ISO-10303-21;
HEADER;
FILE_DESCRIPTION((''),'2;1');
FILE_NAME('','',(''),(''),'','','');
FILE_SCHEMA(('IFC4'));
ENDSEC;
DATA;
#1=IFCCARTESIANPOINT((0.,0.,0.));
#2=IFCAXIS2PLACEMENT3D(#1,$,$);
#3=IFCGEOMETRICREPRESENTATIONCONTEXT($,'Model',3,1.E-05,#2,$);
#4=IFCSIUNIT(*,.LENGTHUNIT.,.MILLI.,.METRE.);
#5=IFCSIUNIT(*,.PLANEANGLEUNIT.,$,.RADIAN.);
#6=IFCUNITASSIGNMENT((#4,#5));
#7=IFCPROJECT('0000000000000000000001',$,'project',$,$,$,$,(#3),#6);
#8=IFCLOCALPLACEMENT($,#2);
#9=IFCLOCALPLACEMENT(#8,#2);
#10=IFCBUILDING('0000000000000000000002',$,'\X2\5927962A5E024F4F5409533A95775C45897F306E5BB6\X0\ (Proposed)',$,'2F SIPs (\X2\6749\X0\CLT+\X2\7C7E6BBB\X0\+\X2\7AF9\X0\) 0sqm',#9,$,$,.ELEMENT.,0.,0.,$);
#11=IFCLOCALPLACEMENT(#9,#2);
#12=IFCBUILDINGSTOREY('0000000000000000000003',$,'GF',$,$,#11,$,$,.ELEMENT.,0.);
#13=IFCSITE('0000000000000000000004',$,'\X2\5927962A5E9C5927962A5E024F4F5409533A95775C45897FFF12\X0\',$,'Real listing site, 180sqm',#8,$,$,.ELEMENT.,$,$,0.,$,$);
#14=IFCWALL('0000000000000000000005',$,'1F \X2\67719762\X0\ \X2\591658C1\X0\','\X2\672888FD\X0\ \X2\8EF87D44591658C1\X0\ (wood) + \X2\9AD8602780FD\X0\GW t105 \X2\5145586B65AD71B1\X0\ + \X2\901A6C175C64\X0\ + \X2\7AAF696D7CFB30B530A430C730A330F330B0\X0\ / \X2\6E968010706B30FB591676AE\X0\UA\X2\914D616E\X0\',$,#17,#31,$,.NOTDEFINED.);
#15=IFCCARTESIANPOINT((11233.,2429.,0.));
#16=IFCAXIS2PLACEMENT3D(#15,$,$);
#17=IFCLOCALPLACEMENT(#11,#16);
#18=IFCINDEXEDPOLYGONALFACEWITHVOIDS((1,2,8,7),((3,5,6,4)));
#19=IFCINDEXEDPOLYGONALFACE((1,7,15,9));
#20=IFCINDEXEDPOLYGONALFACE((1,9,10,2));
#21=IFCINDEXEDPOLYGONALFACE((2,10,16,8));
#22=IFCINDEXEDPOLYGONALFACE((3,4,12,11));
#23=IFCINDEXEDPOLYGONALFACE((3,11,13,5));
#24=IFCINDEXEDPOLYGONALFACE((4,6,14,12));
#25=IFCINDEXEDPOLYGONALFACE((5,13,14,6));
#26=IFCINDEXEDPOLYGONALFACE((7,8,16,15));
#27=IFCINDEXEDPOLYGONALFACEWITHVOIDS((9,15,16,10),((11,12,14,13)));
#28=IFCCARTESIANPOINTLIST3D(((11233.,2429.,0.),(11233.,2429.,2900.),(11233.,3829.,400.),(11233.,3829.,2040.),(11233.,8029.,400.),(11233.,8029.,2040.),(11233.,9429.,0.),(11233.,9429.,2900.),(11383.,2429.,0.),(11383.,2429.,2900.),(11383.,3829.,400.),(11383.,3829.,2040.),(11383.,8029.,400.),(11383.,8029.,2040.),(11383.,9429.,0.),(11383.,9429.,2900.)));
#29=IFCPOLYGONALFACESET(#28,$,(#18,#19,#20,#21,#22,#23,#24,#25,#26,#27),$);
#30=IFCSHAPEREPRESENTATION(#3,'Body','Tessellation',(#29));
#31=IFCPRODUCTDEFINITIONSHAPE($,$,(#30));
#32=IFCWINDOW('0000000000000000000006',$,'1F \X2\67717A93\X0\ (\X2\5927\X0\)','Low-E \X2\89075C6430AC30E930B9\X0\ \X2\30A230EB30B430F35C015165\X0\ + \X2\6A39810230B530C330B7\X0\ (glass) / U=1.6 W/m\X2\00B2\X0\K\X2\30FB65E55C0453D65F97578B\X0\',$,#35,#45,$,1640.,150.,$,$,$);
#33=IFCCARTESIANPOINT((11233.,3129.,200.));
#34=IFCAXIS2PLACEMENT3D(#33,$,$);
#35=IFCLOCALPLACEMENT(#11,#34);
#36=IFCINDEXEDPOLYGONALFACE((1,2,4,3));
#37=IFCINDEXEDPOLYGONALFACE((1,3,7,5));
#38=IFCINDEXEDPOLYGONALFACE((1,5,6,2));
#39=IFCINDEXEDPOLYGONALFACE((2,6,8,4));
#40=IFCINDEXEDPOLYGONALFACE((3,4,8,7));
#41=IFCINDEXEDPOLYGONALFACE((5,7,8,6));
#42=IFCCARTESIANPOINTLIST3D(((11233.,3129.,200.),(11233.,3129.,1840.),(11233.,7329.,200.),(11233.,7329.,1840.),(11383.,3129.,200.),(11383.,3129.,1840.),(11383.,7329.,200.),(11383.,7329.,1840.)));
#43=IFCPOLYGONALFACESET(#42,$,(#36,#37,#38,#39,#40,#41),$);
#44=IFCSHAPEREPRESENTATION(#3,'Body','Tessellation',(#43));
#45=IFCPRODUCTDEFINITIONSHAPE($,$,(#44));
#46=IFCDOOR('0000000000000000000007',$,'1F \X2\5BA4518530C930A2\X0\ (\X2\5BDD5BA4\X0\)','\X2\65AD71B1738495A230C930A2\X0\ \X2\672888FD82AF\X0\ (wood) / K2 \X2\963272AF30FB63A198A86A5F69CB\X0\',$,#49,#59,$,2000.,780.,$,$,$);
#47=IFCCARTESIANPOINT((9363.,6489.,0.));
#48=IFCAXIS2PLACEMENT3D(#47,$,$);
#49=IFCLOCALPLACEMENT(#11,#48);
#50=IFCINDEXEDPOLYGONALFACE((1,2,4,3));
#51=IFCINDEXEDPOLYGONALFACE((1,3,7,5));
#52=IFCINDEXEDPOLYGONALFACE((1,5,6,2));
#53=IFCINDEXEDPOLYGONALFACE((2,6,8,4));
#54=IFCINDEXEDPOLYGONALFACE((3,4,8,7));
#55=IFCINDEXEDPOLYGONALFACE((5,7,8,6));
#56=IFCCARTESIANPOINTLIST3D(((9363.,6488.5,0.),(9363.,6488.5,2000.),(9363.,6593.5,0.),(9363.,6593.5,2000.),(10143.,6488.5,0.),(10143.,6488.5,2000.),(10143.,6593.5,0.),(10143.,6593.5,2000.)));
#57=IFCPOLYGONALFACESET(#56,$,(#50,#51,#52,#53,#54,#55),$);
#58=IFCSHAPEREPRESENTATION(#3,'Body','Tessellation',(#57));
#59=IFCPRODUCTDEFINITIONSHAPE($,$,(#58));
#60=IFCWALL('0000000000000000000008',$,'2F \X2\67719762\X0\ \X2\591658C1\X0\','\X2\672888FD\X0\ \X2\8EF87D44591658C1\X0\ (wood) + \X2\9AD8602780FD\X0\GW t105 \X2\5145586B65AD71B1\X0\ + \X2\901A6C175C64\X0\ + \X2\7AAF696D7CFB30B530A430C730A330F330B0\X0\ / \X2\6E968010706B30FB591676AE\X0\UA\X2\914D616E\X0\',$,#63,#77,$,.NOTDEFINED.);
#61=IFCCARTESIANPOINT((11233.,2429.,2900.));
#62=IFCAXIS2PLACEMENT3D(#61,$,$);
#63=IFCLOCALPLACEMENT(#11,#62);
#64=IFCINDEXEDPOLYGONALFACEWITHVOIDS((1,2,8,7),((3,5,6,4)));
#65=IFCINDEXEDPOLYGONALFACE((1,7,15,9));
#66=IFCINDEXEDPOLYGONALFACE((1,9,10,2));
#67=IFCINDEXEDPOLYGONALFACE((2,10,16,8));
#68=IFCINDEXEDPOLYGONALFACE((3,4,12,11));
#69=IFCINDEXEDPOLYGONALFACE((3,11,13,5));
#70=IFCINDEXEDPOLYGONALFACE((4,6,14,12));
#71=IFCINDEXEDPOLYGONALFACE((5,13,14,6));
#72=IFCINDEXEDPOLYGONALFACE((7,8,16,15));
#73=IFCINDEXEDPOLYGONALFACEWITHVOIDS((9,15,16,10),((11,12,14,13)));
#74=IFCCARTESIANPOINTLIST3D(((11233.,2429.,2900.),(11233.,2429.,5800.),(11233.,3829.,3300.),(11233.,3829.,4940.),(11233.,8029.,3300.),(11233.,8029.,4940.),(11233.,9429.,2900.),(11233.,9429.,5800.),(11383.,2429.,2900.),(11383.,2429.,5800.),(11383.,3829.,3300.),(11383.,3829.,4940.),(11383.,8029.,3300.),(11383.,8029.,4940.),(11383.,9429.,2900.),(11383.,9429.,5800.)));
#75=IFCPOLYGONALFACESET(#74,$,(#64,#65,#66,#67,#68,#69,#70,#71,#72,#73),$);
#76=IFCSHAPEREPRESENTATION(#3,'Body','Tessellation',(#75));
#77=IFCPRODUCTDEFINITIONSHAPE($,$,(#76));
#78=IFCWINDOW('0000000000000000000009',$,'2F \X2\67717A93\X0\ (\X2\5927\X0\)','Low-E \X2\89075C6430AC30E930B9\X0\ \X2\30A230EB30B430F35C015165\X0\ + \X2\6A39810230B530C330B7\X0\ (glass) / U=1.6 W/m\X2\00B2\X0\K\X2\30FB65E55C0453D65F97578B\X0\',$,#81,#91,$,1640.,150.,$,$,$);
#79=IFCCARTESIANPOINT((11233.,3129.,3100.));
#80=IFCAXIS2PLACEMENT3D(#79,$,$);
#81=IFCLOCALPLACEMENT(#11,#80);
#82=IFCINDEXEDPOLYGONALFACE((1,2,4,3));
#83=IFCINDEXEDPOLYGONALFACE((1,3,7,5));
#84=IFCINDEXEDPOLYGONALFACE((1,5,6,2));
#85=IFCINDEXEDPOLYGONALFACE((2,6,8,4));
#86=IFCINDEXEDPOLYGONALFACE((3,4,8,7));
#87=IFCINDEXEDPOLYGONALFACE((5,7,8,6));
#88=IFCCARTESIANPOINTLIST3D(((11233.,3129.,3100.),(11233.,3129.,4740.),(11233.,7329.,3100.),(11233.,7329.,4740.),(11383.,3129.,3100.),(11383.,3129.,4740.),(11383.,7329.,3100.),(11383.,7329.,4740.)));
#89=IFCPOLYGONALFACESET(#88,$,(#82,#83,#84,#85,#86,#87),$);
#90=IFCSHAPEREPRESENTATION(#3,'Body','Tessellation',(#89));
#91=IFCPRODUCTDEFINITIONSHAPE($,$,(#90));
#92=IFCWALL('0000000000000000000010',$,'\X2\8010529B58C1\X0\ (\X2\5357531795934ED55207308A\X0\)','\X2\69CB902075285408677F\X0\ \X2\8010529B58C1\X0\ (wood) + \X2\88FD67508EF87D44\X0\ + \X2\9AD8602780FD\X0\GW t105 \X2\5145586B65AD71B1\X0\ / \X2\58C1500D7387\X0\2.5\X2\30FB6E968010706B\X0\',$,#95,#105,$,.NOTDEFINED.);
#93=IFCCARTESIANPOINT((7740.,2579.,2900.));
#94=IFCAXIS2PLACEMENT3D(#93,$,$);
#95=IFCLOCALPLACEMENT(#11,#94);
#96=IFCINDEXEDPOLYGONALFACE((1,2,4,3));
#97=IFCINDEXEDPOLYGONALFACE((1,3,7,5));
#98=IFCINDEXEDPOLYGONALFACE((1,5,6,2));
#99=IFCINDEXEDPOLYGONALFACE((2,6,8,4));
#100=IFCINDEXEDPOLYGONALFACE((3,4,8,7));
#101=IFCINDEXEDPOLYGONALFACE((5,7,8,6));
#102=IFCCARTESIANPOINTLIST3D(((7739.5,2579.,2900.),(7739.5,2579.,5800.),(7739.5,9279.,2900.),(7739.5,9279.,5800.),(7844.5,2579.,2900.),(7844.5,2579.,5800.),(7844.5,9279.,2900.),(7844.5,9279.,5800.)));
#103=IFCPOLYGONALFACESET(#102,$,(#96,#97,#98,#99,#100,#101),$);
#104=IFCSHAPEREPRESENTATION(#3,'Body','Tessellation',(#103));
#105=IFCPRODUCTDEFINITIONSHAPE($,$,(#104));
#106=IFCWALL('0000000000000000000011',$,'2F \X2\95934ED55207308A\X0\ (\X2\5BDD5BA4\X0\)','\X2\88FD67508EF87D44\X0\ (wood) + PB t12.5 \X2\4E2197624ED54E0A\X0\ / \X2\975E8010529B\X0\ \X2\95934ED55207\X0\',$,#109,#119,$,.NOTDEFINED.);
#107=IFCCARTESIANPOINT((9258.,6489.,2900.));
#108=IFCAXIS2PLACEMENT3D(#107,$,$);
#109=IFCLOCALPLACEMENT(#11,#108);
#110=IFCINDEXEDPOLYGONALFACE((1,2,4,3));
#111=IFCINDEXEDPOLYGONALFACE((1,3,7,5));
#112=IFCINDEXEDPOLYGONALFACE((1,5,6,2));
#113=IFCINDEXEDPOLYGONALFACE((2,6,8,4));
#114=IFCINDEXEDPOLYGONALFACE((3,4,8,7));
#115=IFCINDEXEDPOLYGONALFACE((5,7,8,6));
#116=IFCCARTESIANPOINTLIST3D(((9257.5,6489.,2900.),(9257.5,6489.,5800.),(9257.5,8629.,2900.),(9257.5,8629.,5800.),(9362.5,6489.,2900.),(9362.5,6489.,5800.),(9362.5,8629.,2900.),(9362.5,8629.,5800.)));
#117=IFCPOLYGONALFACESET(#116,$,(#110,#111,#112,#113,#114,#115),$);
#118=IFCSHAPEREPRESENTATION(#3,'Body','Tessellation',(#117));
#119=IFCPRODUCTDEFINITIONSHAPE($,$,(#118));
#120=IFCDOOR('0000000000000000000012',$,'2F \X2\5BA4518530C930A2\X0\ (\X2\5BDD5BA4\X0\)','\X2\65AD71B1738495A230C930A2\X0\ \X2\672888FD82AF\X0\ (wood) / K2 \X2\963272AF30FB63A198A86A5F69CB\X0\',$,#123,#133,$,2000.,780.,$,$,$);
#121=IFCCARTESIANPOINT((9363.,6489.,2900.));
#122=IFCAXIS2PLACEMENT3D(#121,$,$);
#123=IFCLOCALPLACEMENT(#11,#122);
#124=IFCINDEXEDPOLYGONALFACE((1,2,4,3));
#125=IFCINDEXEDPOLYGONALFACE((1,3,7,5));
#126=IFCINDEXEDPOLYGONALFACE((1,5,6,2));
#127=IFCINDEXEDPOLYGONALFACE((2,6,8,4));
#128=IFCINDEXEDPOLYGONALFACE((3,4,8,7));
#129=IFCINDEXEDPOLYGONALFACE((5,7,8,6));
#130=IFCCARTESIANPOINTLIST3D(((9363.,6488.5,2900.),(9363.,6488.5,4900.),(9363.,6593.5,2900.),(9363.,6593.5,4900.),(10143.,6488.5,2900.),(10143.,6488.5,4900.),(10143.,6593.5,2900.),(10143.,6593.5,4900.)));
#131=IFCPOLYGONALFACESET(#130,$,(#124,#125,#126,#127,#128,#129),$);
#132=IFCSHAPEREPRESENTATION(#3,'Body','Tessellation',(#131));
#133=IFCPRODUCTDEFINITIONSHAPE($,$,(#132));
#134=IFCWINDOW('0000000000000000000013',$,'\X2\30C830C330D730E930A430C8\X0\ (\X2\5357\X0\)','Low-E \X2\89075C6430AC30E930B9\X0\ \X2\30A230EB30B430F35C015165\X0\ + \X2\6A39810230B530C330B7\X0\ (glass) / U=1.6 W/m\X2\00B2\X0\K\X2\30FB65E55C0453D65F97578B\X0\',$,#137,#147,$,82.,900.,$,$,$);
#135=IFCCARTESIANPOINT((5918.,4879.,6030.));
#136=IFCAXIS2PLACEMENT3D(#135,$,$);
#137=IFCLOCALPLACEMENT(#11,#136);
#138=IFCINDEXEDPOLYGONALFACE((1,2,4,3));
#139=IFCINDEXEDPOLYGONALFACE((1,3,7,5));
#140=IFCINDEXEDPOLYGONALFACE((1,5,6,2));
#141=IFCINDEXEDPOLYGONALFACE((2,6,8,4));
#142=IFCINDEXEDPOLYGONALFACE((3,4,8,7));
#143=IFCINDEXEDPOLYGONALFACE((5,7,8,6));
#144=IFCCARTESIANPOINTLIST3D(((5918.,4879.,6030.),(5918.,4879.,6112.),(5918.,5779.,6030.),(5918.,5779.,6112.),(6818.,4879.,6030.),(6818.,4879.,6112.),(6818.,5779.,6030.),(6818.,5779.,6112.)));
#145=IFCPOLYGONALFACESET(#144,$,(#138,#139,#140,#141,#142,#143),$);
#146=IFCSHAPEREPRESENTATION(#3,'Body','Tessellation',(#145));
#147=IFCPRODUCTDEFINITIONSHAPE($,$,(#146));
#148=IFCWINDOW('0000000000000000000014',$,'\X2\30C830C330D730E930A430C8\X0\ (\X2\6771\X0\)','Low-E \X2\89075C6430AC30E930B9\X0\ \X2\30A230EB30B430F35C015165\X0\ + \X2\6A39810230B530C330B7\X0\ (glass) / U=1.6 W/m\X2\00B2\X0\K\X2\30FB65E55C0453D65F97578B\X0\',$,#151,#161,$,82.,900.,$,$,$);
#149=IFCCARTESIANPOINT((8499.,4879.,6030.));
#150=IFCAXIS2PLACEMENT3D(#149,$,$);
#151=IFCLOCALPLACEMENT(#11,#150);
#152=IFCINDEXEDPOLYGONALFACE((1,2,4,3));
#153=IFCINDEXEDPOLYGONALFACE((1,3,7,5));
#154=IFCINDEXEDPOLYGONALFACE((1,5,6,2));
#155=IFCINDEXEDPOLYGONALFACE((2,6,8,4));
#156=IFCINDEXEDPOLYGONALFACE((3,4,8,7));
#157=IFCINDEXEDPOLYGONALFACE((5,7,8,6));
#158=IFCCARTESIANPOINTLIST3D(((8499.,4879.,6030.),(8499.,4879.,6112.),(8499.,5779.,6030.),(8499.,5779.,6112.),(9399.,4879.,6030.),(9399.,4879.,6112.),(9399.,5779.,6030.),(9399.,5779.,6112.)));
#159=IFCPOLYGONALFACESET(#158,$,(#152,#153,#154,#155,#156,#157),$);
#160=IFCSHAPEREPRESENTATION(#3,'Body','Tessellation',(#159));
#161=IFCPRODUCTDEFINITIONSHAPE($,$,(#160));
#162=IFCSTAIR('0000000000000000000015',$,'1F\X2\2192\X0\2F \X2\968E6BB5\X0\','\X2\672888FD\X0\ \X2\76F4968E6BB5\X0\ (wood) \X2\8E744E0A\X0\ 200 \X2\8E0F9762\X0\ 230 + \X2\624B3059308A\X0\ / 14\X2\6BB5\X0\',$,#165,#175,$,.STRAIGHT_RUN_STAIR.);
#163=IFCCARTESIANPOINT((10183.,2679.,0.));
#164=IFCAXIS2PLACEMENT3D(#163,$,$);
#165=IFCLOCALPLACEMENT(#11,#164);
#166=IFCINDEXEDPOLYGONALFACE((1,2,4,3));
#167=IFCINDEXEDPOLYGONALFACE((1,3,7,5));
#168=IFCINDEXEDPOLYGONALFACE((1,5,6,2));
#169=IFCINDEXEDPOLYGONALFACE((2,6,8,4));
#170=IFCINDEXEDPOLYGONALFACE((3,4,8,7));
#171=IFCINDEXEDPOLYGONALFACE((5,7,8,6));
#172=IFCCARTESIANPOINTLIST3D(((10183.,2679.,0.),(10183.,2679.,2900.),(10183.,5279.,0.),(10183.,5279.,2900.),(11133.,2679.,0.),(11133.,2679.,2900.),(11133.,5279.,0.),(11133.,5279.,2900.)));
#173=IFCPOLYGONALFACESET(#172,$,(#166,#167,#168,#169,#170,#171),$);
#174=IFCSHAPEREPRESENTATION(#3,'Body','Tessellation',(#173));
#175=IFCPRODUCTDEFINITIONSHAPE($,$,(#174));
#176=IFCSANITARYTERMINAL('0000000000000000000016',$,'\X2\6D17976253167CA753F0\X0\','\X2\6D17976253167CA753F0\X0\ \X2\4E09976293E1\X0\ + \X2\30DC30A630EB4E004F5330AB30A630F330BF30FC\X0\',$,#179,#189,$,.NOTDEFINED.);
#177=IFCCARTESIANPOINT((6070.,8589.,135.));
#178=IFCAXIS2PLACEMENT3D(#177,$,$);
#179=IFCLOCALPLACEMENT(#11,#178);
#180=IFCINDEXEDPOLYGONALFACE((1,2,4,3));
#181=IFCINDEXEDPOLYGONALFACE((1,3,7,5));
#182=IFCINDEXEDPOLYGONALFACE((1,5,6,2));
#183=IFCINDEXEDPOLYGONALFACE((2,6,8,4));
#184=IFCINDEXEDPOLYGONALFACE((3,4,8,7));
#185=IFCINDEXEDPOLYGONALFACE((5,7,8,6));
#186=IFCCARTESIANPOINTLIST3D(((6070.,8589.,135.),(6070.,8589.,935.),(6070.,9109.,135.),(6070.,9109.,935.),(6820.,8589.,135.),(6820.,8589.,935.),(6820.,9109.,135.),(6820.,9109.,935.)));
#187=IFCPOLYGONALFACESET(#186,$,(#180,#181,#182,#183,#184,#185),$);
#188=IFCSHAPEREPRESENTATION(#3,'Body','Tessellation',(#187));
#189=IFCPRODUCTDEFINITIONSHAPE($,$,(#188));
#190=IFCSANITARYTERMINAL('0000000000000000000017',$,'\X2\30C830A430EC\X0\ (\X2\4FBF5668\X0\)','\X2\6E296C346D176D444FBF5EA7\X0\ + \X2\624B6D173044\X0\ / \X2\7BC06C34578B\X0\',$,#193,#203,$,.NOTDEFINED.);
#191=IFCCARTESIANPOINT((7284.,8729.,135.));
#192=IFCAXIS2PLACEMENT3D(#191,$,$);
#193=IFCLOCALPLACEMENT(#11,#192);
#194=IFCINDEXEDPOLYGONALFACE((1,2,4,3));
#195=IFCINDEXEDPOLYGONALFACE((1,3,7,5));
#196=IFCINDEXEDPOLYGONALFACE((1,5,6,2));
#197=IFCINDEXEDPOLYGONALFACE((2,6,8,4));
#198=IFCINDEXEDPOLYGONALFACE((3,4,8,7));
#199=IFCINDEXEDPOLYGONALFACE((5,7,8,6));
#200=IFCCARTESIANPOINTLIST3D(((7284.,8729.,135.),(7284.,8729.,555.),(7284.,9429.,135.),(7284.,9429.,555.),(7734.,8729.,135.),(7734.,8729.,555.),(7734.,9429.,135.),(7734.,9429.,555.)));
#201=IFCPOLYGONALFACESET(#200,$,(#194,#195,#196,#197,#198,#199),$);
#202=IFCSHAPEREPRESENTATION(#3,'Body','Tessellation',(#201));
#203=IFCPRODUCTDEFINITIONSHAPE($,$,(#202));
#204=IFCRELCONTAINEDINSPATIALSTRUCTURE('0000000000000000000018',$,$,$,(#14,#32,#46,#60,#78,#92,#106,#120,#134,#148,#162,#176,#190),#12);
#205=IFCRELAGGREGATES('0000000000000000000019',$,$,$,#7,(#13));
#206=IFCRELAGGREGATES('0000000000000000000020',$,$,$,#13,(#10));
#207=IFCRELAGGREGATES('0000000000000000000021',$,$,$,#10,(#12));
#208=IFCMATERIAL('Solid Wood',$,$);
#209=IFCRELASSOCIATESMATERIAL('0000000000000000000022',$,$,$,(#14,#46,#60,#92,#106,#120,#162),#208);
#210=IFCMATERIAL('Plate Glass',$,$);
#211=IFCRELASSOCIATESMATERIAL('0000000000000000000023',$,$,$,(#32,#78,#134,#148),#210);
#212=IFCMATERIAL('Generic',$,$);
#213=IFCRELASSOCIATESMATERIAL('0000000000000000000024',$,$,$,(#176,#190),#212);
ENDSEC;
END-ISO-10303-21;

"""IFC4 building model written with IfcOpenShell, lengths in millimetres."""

from ifc_helpers import new_model, si_unit, frame, frame_2d, origin, place, context, project, spatial, rectangle, extrude, material, element, fill, save


model = new_model("IFC4")

# Units and contexts
model_context = context("Model", 3, precision=1e-05, world=origin())
ifc_project = project(units=[si_unit("LENGTHUNIT", "METRE", prefix="MILLI"), si_unit("PLANEANGLEUNIT", "RADIAN")], contexts=[model_context])

# Site, building, storey
site_placement = place(None, origin())
site = spatial("IfcSite", under=ifc_project, at=site_placement, Name="大阪府大阪市住吉区長居西２", ObjectType="Real listing site, 180sqm", CompositionType="ELEMENT", RefElevation=0.0)
building_placement = place(site_placement, origin())
building = spatial("IfcBuilding", under=site, at=building_placement, Name="大阪市住吉区長居西の家 (Proposed)", ObjectType="2F SIPs (杉CLT+籾殻+竹) 0sqm", CompositionType="ELEMENT", ElevationOfRefHeight=0.0, ElevationOfTerrain=0.0)
storey_placement = place(building_placement, origin())
storey = spatial("IfcBuildingStorey", under=building, at=storey_placement, Name="GF", CompositionType="ELEMENT", Elevation=0.0)

# Wall, opening, window
ifc_material_1 = material(Name="Solid Wood")
wall_1_placement = place(storey_placement, frame((11233.0, 2429.0, 0.0)))
wall_1 = element("IfcWall", 1, at=wall_1_placement, inside=storey, material=ifc_material_1, Name="1F 東面 外壁", Description="木製 軸組外壁 (wood) + 高性能GW t105 充填断熱 + 通気層 + 窯業系サイディング / 準耐火・外皮UA配慮", PredefinedType="NOTDEFINED", context=model_context, shape_type="SweptSolid", body=[
    extrude(rectangle(XDim=150.0, YDim=7000.0, at=frame_2d((75.0, 3500.0))), frame((11233.0, 2429.0, 0.0)), (0.0, 0.0, 1.0), 2900.0),
])
opening_1_placement = place(storey_placement, frame((11233.0, 3129.0, 200.0)))
opening_1 = element("IfcOpeningElement", 2, at=opening_1_placement, cuts=wall_1, PredefinedType="NOTDEFINED", context=model_context, shape_type="SweptSolid", body=[
    extrude(rectangle(XDim=150.0, YDim=4200.0, at=frame_2d((75.0, 2100.0))), frame((11233.0, 3129.0, 200.0)), (0.0, 0.0, 1.0), 1640.0),
])
ifc_material_2 = material(Name="Plate Glass")
window_1_placement = place(storey_placement, frame((11233.0, 3129.0, 200.0)))
window_1 = element("IfcWindow", 3, at=window_1_placement, inside=storey, material=ifc_material_2, Name="1F 東窓 (大)", Description="Low-E 複層ガラス アルゴン封入 + 樹脂サッシ (glass) / U=1.6 W/m²K・日射取得型", OverallHeight=1640.0, OverallWidth=150.0, context=model_context, shape_type="SweptSolid", body=[
    extrude(rectangle(XDim=150.0, YDim=4200.0, at=frame_2d((75.0, 2100.0))), frame((11233.0, 3129.0, 200.0)), (0.0, 0.0, 1.0), 1640.0),
])
fill(opening_1, window_1)

# Door
door_1_placement = place(storey_placement, frame((9363.0, 6489.0, 0.0)))
element("IfcDoor", 4, at=door_1_placement, inside=storey, material=ifc_material_1, Name="1F 室内ドア (寝室)", Description="断熱玄関ドア 木製芯 (wood) / K2 防犯・採風機構", OverallHeight=2000.0, OverallWidth=780.0, context=model_context, shape_type="SweptSolid", body=[
    extrude(rectangle(XDim=780.0, YDim=105.0, at=frame_2d((390.0, 52.0))), frame((9363.0, 6489.0, 0.0)), (0.0, 0.0, 1.0), 2000.0),
])

# Wall, opening, window
wall_2_placement = place(storey_placement, frame((11233.0, 2429.0, 2900.0)))
wall_2 = element("IfcWall", 5, at=wall_2_placement, inside=storey, material=ifc_material_1, Name="2F 東面 外壁", Description="木製 軸組外壁 (wood) + 高性能GW t105 充填断熱 + 通気層 + 窯業系サイディング / 準耐火・外皮UA配慮", PredefinedType="NOTDEFINED", context=model_context, shape_type="SweptSolid", body=[
    extrude(rectangle(XDim=150.0, YDim=7000.0, at=frame_2d((75.0, 3500.0))), frame((11233.0, 2429.0, 2900.0)), (0.0, 0.0, 1.0), 2900.0),
])
opening_2_placement = place(storey_placement, frame((11233.0, 3129.0, 3100.0)))
opening_2 = element("IfcOpeningElement", 6, at=opening_2_placement, cuts=wall_2, PredefinedType="NOTDEFINED", context=model_context, shape_type="SweptSolid", body=[
    extrude(rectangle(XDim=150.0, YDim=4200.0, at=frame_2d((75.0, 2100.0))), frame((11233.0, 3129.0, 3100.0)), (0.0, 0.0, 1.0), 1640.0),
])
window_2_placement = place(storey_placement, frame((11233.0, 3129.0, 3100.0)))
window_2 = element("IfcWindow", 7, at=window_2_placement, inside=storey, material=ifc_material_2, Name="2F 東窓 (大)", Description="Low-E 複層ガラス アルゴン封入 + 樹脂サッシ (glass) / U=1.6 W/m²K・日射取得型", OverallHeight=1640.0, OverallWidth=150.0, context=model_context, shape_type="SweptSolid", body=[
    extrude(rectangle(XDim=150.0, YDim=4200.0, at=frame_2d((75.0, 2100.0))), frame((11233.0, 3129.0, 3100.0)), (0.0, 0.0, 1.0), 1640.0),
])
fill(opening_2, window_2)

# Walls
wall_3_placement = place(storey_placement, frame((7740.0, 2579.0, 2900.0)))
element("IfcWall", 8, at=wall_3_placement, inside=storey, material=ifc_material_1, Name="耐力壁 (南北間仕切り)", Description="構造用合板 耐力壁 (wood) + 製材軸組 + 高性能GW t105 充填断熱 / 壁倍率2.5・準耐火", PredefinedType="NOTDEFINED", context=model_context, shape_type="SweptSolid", body=[
    extrude(rectangle(XDim=105.0, YDim=6700.0, at=frame_2d((52.0, 3350.0))), frame((7740.0, 2579.0, 2900.0)), (0.0, 0.0, 1.0), 2900.0),
])
wall_4_placement = place(storey_placement, frame((9258.0, 6489.0, 2900.0)))
element("IfcWall", 9, at=wall_4_placement, inside=storey, material=ifc_material_1, Name="2F 間仕切り (寝室)", Description="製材軸組 (wood) + PB t12.5 両面仕上 / 非耐力 間仕切", PredefinedType="NOTDEFINED", context=model_context, shape_type="SweptSolid", body=[
    extrude(rectangle(XDim=105.0, YDim=2140.0, at=frame_2d((52.0, 1070.0))), frame((9258.0, 6489.0, 2900.0)), (0.0, 0.0, 1.0), 2900.0),
])

# Door
door_2_placement = place(storey_placement, frame((9363.0, 6489.0, 2900.0)))
element("IfcDoor", 10, at=door_2_placement, inside=storey, material=ifc_material_1, Name="2F 室内ドア (寝室)", Description="断熱玄関ドア 木製芯 (wood) / K2 防犯・採風機構", OverallHeight=2000.0, OverallWidth=780.0, context=model_context, shape_type="SweptSolid", body=[
    extrude(rectangle(XDim=780.0, YDim=105.0, at=frame_2d((390.0, 52.0))), frame((9363.0, 6489.0, 2900.0)), (0.0, 0.0, 1.0), 2000.0),
])

# Windows
window_3_placement = place(storey_placement, frame((5918.0, 4879.0, 6030.0)))
element("IfcWindow", 11, at=window_3_placement, inside=storey, material=ifc_material_2, Name="トップライト (南)", Description="Low-E 複層ガラス アルゴン封入 + 樹脂サッシ (glass) / U=1.6 W/m²K・日射取得型", OverallHeight=82.0, OverallWidth=900.0, context=model_context, shape_type="SweptSolid", body=[
    extrude(rectangle(XDim=900.0, YDim=900.0, at=frame_2d((450.0, 450.0))), frame((5918.0, 4879.0, 6030.0)), (0.0, 0.0, 1.0), 82.0),
])
window_4_placement = place(storey_placement, frame((8499.0, 4879.0, 6030.0)))
element("IfcWindow", 12, at=window_4_placement, inside=storey, material=ifc_material_2, Name="トップライト (東)", Description="Low-E 複層ガラス アルゴン封入 + 樹脂サッシ (glass) / U=1.6 W/m²K・日射取得型", OverallHeight=82.0, OverallWidth=900.0, context=model_context, shape_type="SweptSolid", body=[
    extrude(rectangle(XDim=900.0, YDim=900.0, at=frame_2d((450.0, 450.0))), frame((8499.0, 4879.0, 6030.0)), (0.0, 0.0, 1.0), 82.0),
])

# Stair
stair_placement = place(storey_placement, frame((10183.0, 2679.0, 0.0)))
element("IfcStair", 13, at=stair_placement, inside=storey, material=ifc_material_1, Name="1F→2F 階段", Description="木製 直階段 (wood) 蹴上 200 踏面 230 + 手すり / 14段", PredefinedType="STRAIGHT_RUN_STAIR", context=model_context, shape_type="SweptSolid", body=[
    extrude(rectangle(XDim=950.0, YDim=2600.0, at=frame_2d((475.0, 1300.0))), frame((10183.0, 2679.0, 0.0)), (0.0, 0.0, 1.0), 2900.0),
])

# Sanitary terminals
ifc_material_3 = material(Name="Generic")
sanitary_terminal_1_placement = place(storey_placement, frame((6070.0, 8589.0, 135.0)))
element("IfcSanitaryTerminal", 14, at=sanitary_terminal_1_placement, inside=storey, material=ifc_material_3, Name="洗面化粧台", Description="洗面化粧台 三面鏡 + ボウル一体カウンター", PredefinedType="NOTDEFINED", context=model_context, shape_type="SweptSolid", body=[
    extrude(rectangle(XDim=750.0, YDim=520.0, at=frame_2d((375.0, 260.0))), frame((6070.0, 8589.0, 135.0)), (0.0, 0.0, 1.0), 800.0),
])
sanitary_terminal_2_placement = place(storey_placement, frame((7284.0, 8729.0, 135.0)))
element("IfcSanitaryTerminal", 15, at=sanitary_terminal_2_placement, inside=storey, material=ifc_material_3, Name="トイレ (便器)", Description="温水洗浄便座 + 手洗い / 節水型", PredefinedType="NOTDEFINED", context=model_context, shape_type="SweptSolid", body=[
    extrude(rectangle(XDim=450.0, YDim=700.0, at=frame_2d((225.0, 350.0))), frame((7284.0, 8729.0, 135.0)), (0.0, 0.0, 1.0), 420.0),
])

save(model, "model.ifc")
